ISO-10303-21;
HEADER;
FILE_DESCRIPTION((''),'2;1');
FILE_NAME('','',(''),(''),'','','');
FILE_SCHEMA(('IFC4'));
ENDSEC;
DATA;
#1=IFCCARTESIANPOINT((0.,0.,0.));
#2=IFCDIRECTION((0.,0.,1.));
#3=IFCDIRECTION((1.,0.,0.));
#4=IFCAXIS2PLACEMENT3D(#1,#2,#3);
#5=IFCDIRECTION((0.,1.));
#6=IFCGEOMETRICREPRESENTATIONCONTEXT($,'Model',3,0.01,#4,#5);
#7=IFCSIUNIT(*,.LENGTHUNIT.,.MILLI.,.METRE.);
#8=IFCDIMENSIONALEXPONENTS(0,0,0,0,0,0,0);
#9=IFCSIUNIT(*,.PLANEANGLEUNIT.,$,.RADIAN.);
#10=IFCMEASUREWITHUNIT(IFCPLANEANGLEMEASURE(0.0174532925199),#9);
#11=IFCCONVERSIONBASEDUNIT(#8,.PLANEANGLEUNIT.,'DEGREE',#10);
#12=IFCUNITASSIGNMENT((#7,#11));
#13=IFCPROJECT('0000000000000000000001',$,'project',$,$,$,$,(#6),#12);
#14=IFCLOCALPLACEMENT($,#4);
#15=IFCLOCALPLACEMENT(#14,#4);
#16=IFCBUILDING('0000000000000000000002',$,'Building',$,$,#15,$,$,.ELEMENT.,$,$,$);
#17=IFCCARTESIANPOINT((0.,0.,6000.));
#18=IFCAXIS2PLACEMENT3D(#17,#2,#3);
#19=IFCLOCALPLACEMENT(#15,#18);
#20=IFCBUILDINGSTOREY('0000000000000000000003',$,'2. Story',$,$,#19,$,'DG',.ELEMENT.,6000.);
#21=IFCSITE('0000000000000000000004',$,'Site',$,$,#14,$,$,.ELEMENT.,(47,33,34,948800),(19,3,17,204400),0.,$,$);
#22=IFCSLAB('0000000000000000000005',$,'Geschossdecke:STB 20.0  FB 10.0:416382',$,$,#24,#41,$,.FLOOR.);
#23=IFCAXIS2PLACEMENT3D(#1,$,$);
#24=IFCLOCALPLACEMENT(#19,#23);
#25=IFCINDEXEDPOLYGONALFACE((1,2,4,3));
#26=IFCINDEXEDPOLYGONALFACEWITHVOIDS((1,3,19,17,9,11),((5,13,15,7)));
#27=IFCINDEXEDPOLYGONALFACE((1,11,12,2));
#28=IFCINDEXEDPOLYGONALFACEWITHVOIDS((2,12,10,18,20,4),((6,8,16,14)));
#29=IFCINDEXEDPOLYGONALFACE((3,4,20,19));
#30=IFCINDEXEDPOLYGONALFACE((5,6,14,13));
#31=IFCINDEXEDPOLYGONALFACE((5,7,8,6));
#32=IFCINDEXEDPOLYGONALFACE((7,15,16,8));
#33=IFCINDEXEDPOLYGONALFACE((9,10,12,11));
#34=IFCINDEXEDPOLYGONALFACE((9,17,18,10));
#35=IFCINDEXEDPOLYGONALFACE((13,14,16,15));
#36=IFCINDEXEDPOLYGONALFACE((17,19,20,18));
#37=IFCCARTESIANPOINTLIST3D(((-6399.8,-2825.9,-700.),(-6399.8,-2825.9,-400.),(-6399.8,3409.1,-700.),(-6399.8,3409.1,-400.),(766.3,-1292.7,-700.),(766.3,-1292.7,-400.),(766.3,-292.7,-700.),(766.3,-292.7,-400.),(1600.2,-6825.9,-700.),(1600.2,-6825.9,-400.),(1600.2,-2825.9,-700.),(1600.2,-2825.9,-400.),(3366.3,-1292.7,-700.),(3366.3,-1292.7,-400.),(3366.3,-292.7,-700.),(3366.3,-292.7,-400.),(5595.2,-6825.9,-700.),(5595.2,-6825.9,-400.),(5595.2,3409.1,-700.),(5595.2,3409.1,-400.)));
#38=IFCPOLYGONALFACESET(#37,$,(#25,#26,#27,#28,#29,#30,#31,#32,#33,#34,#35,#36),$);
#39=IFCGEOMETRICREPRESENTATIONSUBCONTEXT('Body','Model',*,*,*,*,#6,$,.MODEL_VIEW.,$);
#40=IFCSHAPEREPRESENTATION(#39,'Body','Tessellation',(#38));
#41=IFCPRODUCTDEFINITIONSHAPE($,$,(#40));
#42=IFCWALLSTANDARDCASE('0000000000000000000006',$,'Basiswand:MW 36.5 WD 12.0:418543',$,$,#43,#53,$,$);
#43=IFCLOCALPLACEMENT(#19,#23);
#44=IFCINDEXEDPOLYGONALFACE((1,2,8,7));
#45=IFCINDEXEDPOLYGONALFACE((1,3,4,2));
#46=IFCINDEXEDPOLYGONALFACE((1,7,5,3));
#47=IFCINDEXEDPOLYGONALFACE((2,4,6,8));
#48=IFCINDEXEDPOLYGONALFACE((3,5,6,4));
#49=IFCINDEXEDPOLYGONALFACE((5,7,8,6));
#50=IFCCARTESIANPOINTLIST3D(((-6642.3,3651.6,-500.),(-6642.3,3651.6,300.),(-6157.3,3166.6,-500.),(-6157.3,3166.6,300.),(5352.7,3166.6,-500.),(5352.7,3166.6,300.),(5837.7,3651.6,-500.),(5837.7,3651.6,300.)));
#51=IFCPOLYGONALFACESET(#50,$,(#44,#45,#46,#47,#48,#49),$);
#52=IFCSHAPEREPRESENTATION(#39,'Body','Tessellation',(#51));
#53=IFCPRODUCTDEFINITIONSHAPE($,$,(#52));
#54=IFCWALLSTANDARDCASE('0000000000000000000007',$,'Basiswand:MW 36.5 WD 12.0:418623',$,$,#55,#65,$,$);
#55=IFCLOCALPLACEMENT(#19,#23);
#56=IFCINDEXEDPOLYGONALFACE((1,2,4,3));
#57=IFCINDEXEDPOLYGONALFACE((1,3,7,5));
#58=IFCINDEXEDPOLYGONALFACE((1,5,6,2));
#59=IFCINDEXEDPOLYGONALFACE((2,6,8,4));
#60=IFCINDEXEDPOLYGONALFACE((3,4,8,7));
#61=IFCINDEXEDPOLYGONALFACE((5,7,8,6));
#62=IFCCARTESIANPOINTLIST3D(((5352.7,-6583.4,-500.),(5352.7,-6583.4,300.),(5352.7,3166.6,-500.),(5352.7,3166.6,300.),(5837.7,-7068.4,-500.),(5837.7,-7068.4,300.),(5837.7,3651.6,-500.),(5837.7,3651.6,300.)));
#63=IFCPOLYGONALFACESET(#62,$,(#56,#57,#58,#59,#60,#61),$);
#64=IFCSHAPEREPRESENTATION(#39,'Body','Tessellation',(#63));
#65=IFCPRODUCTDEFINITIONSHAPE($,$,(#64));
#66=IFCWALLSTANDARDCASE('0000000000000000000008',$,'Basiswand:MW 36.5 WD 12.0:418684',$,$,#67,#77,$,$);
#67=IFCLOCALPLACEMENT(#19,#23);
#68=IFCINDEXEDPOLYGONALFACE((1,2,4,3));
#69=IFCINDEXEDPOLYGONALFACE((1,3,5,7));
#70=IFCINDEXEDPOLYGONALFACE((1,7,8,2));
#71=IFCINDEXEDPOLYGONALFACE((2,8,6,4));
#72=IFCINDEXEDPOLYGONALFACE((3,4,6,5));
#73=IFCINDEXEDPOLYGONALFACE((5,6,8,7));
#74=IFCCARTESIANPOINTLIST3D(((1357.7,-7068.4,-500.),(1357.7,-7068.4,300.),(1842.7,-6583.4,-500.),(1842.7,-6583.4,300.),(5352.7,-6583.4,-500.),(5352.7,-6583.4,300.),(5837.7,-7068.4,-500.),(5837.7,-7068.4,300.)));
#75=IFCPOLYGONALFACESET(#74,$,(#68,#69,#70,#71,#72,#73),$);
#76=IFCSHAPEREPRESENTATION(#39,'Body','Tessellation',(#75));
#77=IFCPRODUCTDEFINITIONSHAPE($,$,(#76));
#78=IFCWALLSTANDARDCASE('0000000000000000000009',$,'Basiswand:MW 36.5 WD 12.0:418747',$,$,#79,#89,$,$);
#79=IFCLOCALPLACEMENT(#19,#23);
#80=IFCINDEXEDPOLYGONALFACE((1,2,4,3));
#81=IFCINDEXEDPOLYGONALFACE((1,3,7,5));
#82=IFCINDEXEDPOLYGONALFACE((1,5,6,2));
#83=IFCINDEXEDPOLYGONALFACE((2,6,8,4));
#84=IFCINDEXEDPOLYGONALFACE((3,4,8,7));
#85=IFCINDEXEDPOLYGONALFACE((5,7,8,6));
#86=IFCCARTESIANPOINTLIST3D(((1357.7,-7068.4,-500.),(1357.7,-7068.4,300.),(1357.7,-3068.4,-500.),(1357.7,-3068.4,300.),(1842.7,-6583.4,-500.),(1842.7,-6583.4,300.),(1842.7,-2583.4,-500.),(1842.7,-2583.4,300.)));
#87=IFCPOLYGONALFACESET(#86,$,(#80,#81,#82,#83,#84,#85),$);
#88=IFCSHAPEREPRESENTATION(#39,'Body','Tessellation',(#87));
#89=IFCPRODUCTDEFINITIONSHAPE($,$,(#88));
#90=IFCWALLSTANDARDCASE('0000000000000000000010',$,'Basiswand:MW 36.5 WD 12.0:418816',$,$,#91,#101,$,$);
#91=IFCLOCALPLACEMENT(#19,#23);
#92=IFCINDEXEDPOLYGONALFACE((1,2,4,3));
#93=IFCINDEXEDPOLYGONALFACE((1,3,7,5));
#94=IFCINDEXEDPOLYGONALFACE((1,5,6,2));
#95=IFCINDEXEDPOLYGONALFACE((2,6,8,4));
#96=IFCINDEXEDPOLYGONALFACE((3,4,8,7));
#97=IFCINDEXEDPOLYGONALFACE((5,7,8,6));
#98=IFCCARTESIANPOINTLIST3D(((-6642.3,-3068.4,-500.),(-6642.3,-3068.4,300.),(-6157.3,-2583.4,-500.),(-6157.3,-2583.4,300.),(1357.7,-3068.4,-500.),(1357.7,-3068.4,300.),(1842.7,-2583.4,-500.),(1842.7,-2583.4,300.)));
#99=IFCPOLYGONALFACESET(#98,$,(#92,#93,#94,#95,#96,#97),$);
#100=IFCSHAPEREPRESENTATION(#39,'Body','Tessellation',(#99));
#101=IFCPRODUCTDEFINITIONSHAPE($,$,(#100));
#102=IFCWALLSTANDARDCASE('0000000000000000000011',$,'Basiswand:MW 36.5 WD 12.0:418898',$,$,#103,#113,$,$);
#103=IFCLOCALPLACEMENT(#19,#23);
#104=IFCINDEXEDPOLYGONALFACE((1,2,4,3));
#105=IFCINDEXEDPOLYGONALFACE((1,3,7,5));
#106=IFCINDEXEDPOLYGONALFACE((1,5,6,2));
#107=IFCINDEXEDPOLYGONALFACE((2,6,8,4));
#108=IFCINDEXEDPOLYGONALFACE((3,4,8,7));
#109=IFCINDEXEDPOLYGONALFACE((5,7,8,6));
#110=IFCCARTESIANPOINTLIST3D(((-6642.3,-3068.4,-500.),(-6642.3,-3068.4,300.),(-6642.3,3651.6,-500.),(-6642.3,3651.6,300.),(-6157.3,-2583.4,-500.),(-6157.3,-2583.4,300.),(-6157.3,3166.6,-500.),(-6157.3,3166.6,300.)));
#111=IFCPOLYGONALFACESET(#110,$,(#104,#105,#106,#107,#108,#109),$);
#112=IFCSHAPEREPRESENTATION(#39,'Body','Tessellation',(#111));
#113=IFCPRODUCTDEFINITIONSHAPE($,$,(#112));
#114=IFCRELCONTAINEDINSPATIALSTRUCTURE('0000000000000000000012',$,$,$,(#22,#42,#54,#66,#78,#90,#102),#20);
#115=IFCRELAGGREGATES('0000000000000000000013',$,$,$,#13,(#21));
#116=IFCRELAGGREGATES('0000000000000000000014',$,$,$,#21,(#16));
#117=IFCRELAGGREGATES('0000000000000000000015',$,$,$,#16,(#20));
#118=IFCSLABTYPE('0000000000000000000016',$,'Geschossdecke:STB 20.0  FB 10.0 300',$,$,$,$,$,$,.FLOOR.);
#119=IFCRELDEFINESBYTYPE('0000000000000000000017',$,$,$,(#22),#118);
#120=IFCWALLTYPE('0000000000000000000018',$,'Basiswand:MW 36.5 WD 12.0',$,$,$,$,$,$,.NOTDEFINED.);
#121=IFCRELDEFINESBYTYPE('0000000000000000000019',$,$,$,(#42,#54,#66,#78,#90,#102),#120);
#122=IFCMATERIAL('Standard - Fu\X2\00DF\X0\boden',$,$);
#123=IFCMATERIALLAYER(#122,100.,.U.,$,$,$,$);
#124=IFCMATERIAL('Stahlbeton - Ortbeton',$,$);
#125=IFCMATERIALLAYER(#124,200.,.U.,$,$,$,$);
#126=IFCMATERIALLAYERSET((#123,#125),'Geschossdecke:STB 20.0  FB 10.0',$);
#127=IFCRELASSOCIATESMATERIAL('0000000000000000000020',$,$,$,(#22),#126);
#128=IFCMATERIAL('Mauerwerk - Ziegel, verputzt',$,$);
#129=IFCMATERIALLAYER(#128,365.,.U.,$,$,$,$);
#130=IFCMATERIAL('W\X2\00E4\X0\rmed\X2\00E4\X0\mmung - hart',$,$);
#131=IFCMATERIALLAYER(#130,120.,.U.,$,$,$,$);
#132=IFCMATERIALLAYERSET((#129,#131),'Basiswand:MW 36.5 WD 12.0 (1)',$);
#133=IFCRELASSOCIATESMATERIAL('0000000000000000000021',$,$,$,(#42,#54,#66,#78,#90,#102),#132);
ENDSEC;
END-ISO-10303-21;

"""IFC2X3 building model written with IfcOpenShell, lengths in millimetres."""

from ifc_helpers import new_model, entity, si_unit, converted_unit, direction, frame, origin_with_axes, origin_2d_with_axis, place, context, subcontext, project, spatial, polyline, rectangle, outline, extrude, material, layer, layer_set, layer_usage, type_object, element, save


model = new_model("IFC2X3")

# Units and contexts
model_context = context("Model", 3, precision=0.01, world=origin_with_axes(), true_north=direction((0.0, 1.0)))
body_context = subcontext(model_context, "Body", "Model", "MODEL_VIEW")
ifc_project = project(units=[si_unit("LENGTHUNIT", "METRE", prefix="MILLI"), converted_unit("PLANEANGLEUNIT", "DEGREE", entity("IfcPlaneAngleMeasure", 0.0174532925199), si_unit("PLANEANGLEUNIT", "RADIAN"), dimensions=[0, 0, 0, 0, 0, 0, 0])], contexts=[model_context])

# Site, building, storey
site_placement = place(None, origin_with_axes())
site = spatial("IfcSite", under=ifc_project, at=site_placement, Name="Site", CompositionType="ELEMENT", RefLatitude=(47, 33, 34, 948800), RefLongitude=(19, 3, 17, 204400), RefElevation=0.0)
building_placement = place(site_placement, origin_with_axes())
building = spatial("IfcBuilding", under=site, at=building_placement, Name="Building", CompositionType="ELEMENT")
storey_placement = place(building_placement, frame((0.0, 0.0, 6000.0), z_axis=(0.0, 0.0, 1.0), x_axis=(1.0, 0.0, 0.0)))
storey = spatial("IfcBuildingStorey", under=building, at=storey_placement, Name="2. Story", LongName="DG", CompositionType="ELEMENT", Elevation=6000.0)

# Slab, opening
ifc_material_1 = material(Name="Standard - Fußboden")
ifc_layer_1 = layer(ifc_material_1, 100.0, ventilated="UNKNOWN")
ifc_material_2 = material(Name="Stahlbeton - Ortbeton")
ifc_layer_2 = layer(ifc_material_2, 200.0, ventilated="UNKNOWN")
ifc_layer_set_1 = layer_set([ifc_layer_1, ifc_layer_2], Name="Geschossdecke:STB 20.0  FB 10.0")
ifc_layer_usage_1 = layer_usage(ifc_layer_set_1, "AXIS3", "NEGATIVE", 300.0)
slab_type = type_object("IfcSlabType", Name="Geschossdecke:STB 20.0  FB 10.0 300", PredefinedType="FLOOR")
slab_placement = place(storey_placement, frame((-6399.8, -2825.9, -700.0), z_axis=(0.0, 0.0, 1.0), x_axis=(1.0, 0.0, 0.0)))
slab = element("IfcSlab", 1, at=slab_placement, inside=storey, type_object=slab_type, material=ifc_layer_usage_1, Name="Geschossdecke:STB 20.0  FB 10.0:416382", PredefinedType="FLOOR", context=body_context, shape_type="SweptSolid", body=[
    extrude(outline(polyline([(0.0, 0.0), (8000.0, 0.0), (8000.0, -4000.0), (11995.0, -4000.0), (11995.0, 6235.0), (0.0, 6235.0), (0.0, 0.0)])), origin_with_axes(), (0.0, 0.0, 1.0), 300.0),
])
opening_placement = place(slab_placement, frame((6399.8, 2825.9, -5300.0), z_axis=(0.0, 0.0, 1.0), x_axis=(1.0, 0.0, 0.0)))
element("IfcOpeningElement", 2, at=opening_placement, cuts=slab, ObjectType="OPENING", context=body_context, shape_type="SweptSolid", body=[
    extrude(rectangle(XDim=2600.0, YDim=1000.0, at=origin_2d_with_axis()), frame((2066.3, -792.7, 5600.0), z_axis=(0.0, 0.0, -1.0), x_axis=(1.0, 0.0, 0.0)), (0.0, 0.0, 1.0), 300.0),
])

# Walls
ifc_material_3 = material(Name="Mauerwerk - Ziegel, verputzt")
ifc_layer_3 = layer(ifc_material_3, 365.0, ventilated="UNKNOWN")
ifc_material_4 = material(Name="Wärmedämmung - hart")
ifc_layer_4 = layer(ifc_material_4, 120.0, ventilated="UNKNOWN")
ifc_layer_set_2 = layer_set([ifc_layer_3, ifc_layer_4], Name="Basiswand:MW 36.5 WD 12.0 (1)")
ifc_layer_usage_2 = layer_usage(ifc_layer_set_2, "AXIS2", "POSITIVE", -242.5)
wall_type = type_object("IfcWallType", Name="Basiswand:MW 36.5 WD 12.0", PredefinedType="NOTDEFINED")
wall_1_placement = place(storey_placement, frame((-6399.8, 3409.1, -500.0), z_axis=(0.0, 0.0, 1.0), x_axis=(1.0, 0.0, 0.0)))
element("IfcWallStandardCase", 3, at=wall_1_placement, inside=storey, type_object=wall_type, material=ifc_layer_usage_2, Name="Basiswand:MW 36.5 WD 12.0:418543", context=body_context, shape_type="SweptSolid", body=[
    extrude(outline(polyline([(242.5, -242.5), (11752.5, -242.5), (12237.5, 242.5), (-242.5, 242.5), (242.5, -242.5)])), origin_with_axes(), (0.0, 0.0, 1.0), 800.0),
])
ifc_layer_usage_3 = layer_usage(ifc_layer_set_2, "AXIS2", "POSITIVE", -242.5)
wall_2_placement = place(storey_placement, frame((5595.2, 3409.1, -500.0), z_axis=(0.0, 0.0, 1.0), x_axis=(0.0, -1.0, 0.0)))
element("IfcWallStandardCase", 4, at=wall_2_placement, inside=storey, type_object=wall_type, material=ifc_layer_usage_3, Name="Basiswand:MW 36.5 WD 12.0:418623", context=body_context, shape_type="SweptSolid", body=[
    extrude(outline(polyline([(242.5, -242.5), (9992.5, -242.5), (10477.5, 242.5), (-242.5, 242.5), (242.5, -242.5)])), origin_with_axes(), (0.0, 0.0, 1.0), 800.0),
])
ifc_layer_usage_4 = layer_usage(ifc_layer_set_2, "AXIS2", "POSITIVE", -242.5)
wall_3_placement = place(storey_placement, frame((5595.2, -6825.9, -500.0), z_axis=(0.0, 0.0, 1.0), x_axis=(-1.0, 0.0, 0.0)))
element("IfcWallStandardCase", 5, at=wall_3_placement, inside=storey, type_object=wall_type, material=ifc_layer_usage_4, Name="Basiswand:MW 36.5 WD 12.0:418684", context=body_context, shape_type="SweptSolid", body=[
    extrude(outline(polyline([(242.5, -242.5), (3752.5, -242.5), (4237.5, 242.5), (-242.5, 242.5), (242.5, -242.5)])), origin_with_axes(), (0.0, 0.0, 1.0), 800.0),
])
ifc_layer_usage_5 = layer_usage(ifc_layer_set_2, "AXIS2", "POSITIVE", -242.5)
wall_4_placement = place(storey_placement, frame((1600.2, -6825.9, -500.0), z_axis=(0.0, 0.0, 1.0), x_axis=(0.0, 1.0, 0.0)))
element("IfcWallStandardCase", 6, at=wall_4_placement, inside=storey, type_object=wall_type, material=ifc_layer_usage_5, Name="Basiswand:MW 36.5 WD 12.0:418747", context=body_context, shape_type="SweptSolid", body=[
    extrude(outline(polyline([(242.5, -242.5), (4242.5, -242.5), (3757.5, 242.5), (-242.5, 242.5), (242.5, -242.5)])), origin_with_axes(), (0.0, 0.0, 1.0), 800.0),
])
ifc_layer_usage_6 = layer_usage(ifc_layer_set_2, "AXIS2", "POSITIVE", -242.5)
wall_5_placement = place(storey_placement, frame((1600.2, -2825.9, -500.0), z_axis=(0.0, 0.0, 1.0), x_axis=(-1.0, 0.0, 0.0)))
element("IfcWallStandardCase", 7, at=wall_5_placement, inside=storey, type_object=wall_type, material=ifc_layer_usage_6, Name="Basiswand:MW 36.5 WD 12.0:418816", context=body_context, shape_type="SweptSolid", body=[
    extrude(outline(polyline([(-242.5, -242.5), (7757.5, -242.5), (8242.5, 242.5), (242.5, 242.5), (-242.5, -242.5)])), origin_with_axes(), (0.0, 0.0, 1.0), 800.0),
])
ifc_layer_usage_7 = layer_usage(ifc_layer_set_2, "AXIS2", "POSITIVE", -242.5)
wall_6_placement = place(storey_placement, frame((-6399.8, -2825.9, -500.0), z_axis=(0.0, 0.0, 1.0), x_axis=(0.0, 1.0, 0.0)))
element("IfcWallStandardCase", 8, at=wall_6_placement, inside=storey, type_object=wall_type, material=ifc_layer_usage_7, Name="Basiswand:MW 36.5 WD 12.0:418898", context=body_context, shape_type="SweptSolid", body=[
    extrude(outline(polyline([(242.5, -242.5), (5992.5, -242.5), (6477.5, 242.5), (-242.5, 242.5), (242.5, -242.5)])), origin_with_axes(), (0.0, 0.0, 1.0), 800.0),
])

save(model, "model.ifc")
